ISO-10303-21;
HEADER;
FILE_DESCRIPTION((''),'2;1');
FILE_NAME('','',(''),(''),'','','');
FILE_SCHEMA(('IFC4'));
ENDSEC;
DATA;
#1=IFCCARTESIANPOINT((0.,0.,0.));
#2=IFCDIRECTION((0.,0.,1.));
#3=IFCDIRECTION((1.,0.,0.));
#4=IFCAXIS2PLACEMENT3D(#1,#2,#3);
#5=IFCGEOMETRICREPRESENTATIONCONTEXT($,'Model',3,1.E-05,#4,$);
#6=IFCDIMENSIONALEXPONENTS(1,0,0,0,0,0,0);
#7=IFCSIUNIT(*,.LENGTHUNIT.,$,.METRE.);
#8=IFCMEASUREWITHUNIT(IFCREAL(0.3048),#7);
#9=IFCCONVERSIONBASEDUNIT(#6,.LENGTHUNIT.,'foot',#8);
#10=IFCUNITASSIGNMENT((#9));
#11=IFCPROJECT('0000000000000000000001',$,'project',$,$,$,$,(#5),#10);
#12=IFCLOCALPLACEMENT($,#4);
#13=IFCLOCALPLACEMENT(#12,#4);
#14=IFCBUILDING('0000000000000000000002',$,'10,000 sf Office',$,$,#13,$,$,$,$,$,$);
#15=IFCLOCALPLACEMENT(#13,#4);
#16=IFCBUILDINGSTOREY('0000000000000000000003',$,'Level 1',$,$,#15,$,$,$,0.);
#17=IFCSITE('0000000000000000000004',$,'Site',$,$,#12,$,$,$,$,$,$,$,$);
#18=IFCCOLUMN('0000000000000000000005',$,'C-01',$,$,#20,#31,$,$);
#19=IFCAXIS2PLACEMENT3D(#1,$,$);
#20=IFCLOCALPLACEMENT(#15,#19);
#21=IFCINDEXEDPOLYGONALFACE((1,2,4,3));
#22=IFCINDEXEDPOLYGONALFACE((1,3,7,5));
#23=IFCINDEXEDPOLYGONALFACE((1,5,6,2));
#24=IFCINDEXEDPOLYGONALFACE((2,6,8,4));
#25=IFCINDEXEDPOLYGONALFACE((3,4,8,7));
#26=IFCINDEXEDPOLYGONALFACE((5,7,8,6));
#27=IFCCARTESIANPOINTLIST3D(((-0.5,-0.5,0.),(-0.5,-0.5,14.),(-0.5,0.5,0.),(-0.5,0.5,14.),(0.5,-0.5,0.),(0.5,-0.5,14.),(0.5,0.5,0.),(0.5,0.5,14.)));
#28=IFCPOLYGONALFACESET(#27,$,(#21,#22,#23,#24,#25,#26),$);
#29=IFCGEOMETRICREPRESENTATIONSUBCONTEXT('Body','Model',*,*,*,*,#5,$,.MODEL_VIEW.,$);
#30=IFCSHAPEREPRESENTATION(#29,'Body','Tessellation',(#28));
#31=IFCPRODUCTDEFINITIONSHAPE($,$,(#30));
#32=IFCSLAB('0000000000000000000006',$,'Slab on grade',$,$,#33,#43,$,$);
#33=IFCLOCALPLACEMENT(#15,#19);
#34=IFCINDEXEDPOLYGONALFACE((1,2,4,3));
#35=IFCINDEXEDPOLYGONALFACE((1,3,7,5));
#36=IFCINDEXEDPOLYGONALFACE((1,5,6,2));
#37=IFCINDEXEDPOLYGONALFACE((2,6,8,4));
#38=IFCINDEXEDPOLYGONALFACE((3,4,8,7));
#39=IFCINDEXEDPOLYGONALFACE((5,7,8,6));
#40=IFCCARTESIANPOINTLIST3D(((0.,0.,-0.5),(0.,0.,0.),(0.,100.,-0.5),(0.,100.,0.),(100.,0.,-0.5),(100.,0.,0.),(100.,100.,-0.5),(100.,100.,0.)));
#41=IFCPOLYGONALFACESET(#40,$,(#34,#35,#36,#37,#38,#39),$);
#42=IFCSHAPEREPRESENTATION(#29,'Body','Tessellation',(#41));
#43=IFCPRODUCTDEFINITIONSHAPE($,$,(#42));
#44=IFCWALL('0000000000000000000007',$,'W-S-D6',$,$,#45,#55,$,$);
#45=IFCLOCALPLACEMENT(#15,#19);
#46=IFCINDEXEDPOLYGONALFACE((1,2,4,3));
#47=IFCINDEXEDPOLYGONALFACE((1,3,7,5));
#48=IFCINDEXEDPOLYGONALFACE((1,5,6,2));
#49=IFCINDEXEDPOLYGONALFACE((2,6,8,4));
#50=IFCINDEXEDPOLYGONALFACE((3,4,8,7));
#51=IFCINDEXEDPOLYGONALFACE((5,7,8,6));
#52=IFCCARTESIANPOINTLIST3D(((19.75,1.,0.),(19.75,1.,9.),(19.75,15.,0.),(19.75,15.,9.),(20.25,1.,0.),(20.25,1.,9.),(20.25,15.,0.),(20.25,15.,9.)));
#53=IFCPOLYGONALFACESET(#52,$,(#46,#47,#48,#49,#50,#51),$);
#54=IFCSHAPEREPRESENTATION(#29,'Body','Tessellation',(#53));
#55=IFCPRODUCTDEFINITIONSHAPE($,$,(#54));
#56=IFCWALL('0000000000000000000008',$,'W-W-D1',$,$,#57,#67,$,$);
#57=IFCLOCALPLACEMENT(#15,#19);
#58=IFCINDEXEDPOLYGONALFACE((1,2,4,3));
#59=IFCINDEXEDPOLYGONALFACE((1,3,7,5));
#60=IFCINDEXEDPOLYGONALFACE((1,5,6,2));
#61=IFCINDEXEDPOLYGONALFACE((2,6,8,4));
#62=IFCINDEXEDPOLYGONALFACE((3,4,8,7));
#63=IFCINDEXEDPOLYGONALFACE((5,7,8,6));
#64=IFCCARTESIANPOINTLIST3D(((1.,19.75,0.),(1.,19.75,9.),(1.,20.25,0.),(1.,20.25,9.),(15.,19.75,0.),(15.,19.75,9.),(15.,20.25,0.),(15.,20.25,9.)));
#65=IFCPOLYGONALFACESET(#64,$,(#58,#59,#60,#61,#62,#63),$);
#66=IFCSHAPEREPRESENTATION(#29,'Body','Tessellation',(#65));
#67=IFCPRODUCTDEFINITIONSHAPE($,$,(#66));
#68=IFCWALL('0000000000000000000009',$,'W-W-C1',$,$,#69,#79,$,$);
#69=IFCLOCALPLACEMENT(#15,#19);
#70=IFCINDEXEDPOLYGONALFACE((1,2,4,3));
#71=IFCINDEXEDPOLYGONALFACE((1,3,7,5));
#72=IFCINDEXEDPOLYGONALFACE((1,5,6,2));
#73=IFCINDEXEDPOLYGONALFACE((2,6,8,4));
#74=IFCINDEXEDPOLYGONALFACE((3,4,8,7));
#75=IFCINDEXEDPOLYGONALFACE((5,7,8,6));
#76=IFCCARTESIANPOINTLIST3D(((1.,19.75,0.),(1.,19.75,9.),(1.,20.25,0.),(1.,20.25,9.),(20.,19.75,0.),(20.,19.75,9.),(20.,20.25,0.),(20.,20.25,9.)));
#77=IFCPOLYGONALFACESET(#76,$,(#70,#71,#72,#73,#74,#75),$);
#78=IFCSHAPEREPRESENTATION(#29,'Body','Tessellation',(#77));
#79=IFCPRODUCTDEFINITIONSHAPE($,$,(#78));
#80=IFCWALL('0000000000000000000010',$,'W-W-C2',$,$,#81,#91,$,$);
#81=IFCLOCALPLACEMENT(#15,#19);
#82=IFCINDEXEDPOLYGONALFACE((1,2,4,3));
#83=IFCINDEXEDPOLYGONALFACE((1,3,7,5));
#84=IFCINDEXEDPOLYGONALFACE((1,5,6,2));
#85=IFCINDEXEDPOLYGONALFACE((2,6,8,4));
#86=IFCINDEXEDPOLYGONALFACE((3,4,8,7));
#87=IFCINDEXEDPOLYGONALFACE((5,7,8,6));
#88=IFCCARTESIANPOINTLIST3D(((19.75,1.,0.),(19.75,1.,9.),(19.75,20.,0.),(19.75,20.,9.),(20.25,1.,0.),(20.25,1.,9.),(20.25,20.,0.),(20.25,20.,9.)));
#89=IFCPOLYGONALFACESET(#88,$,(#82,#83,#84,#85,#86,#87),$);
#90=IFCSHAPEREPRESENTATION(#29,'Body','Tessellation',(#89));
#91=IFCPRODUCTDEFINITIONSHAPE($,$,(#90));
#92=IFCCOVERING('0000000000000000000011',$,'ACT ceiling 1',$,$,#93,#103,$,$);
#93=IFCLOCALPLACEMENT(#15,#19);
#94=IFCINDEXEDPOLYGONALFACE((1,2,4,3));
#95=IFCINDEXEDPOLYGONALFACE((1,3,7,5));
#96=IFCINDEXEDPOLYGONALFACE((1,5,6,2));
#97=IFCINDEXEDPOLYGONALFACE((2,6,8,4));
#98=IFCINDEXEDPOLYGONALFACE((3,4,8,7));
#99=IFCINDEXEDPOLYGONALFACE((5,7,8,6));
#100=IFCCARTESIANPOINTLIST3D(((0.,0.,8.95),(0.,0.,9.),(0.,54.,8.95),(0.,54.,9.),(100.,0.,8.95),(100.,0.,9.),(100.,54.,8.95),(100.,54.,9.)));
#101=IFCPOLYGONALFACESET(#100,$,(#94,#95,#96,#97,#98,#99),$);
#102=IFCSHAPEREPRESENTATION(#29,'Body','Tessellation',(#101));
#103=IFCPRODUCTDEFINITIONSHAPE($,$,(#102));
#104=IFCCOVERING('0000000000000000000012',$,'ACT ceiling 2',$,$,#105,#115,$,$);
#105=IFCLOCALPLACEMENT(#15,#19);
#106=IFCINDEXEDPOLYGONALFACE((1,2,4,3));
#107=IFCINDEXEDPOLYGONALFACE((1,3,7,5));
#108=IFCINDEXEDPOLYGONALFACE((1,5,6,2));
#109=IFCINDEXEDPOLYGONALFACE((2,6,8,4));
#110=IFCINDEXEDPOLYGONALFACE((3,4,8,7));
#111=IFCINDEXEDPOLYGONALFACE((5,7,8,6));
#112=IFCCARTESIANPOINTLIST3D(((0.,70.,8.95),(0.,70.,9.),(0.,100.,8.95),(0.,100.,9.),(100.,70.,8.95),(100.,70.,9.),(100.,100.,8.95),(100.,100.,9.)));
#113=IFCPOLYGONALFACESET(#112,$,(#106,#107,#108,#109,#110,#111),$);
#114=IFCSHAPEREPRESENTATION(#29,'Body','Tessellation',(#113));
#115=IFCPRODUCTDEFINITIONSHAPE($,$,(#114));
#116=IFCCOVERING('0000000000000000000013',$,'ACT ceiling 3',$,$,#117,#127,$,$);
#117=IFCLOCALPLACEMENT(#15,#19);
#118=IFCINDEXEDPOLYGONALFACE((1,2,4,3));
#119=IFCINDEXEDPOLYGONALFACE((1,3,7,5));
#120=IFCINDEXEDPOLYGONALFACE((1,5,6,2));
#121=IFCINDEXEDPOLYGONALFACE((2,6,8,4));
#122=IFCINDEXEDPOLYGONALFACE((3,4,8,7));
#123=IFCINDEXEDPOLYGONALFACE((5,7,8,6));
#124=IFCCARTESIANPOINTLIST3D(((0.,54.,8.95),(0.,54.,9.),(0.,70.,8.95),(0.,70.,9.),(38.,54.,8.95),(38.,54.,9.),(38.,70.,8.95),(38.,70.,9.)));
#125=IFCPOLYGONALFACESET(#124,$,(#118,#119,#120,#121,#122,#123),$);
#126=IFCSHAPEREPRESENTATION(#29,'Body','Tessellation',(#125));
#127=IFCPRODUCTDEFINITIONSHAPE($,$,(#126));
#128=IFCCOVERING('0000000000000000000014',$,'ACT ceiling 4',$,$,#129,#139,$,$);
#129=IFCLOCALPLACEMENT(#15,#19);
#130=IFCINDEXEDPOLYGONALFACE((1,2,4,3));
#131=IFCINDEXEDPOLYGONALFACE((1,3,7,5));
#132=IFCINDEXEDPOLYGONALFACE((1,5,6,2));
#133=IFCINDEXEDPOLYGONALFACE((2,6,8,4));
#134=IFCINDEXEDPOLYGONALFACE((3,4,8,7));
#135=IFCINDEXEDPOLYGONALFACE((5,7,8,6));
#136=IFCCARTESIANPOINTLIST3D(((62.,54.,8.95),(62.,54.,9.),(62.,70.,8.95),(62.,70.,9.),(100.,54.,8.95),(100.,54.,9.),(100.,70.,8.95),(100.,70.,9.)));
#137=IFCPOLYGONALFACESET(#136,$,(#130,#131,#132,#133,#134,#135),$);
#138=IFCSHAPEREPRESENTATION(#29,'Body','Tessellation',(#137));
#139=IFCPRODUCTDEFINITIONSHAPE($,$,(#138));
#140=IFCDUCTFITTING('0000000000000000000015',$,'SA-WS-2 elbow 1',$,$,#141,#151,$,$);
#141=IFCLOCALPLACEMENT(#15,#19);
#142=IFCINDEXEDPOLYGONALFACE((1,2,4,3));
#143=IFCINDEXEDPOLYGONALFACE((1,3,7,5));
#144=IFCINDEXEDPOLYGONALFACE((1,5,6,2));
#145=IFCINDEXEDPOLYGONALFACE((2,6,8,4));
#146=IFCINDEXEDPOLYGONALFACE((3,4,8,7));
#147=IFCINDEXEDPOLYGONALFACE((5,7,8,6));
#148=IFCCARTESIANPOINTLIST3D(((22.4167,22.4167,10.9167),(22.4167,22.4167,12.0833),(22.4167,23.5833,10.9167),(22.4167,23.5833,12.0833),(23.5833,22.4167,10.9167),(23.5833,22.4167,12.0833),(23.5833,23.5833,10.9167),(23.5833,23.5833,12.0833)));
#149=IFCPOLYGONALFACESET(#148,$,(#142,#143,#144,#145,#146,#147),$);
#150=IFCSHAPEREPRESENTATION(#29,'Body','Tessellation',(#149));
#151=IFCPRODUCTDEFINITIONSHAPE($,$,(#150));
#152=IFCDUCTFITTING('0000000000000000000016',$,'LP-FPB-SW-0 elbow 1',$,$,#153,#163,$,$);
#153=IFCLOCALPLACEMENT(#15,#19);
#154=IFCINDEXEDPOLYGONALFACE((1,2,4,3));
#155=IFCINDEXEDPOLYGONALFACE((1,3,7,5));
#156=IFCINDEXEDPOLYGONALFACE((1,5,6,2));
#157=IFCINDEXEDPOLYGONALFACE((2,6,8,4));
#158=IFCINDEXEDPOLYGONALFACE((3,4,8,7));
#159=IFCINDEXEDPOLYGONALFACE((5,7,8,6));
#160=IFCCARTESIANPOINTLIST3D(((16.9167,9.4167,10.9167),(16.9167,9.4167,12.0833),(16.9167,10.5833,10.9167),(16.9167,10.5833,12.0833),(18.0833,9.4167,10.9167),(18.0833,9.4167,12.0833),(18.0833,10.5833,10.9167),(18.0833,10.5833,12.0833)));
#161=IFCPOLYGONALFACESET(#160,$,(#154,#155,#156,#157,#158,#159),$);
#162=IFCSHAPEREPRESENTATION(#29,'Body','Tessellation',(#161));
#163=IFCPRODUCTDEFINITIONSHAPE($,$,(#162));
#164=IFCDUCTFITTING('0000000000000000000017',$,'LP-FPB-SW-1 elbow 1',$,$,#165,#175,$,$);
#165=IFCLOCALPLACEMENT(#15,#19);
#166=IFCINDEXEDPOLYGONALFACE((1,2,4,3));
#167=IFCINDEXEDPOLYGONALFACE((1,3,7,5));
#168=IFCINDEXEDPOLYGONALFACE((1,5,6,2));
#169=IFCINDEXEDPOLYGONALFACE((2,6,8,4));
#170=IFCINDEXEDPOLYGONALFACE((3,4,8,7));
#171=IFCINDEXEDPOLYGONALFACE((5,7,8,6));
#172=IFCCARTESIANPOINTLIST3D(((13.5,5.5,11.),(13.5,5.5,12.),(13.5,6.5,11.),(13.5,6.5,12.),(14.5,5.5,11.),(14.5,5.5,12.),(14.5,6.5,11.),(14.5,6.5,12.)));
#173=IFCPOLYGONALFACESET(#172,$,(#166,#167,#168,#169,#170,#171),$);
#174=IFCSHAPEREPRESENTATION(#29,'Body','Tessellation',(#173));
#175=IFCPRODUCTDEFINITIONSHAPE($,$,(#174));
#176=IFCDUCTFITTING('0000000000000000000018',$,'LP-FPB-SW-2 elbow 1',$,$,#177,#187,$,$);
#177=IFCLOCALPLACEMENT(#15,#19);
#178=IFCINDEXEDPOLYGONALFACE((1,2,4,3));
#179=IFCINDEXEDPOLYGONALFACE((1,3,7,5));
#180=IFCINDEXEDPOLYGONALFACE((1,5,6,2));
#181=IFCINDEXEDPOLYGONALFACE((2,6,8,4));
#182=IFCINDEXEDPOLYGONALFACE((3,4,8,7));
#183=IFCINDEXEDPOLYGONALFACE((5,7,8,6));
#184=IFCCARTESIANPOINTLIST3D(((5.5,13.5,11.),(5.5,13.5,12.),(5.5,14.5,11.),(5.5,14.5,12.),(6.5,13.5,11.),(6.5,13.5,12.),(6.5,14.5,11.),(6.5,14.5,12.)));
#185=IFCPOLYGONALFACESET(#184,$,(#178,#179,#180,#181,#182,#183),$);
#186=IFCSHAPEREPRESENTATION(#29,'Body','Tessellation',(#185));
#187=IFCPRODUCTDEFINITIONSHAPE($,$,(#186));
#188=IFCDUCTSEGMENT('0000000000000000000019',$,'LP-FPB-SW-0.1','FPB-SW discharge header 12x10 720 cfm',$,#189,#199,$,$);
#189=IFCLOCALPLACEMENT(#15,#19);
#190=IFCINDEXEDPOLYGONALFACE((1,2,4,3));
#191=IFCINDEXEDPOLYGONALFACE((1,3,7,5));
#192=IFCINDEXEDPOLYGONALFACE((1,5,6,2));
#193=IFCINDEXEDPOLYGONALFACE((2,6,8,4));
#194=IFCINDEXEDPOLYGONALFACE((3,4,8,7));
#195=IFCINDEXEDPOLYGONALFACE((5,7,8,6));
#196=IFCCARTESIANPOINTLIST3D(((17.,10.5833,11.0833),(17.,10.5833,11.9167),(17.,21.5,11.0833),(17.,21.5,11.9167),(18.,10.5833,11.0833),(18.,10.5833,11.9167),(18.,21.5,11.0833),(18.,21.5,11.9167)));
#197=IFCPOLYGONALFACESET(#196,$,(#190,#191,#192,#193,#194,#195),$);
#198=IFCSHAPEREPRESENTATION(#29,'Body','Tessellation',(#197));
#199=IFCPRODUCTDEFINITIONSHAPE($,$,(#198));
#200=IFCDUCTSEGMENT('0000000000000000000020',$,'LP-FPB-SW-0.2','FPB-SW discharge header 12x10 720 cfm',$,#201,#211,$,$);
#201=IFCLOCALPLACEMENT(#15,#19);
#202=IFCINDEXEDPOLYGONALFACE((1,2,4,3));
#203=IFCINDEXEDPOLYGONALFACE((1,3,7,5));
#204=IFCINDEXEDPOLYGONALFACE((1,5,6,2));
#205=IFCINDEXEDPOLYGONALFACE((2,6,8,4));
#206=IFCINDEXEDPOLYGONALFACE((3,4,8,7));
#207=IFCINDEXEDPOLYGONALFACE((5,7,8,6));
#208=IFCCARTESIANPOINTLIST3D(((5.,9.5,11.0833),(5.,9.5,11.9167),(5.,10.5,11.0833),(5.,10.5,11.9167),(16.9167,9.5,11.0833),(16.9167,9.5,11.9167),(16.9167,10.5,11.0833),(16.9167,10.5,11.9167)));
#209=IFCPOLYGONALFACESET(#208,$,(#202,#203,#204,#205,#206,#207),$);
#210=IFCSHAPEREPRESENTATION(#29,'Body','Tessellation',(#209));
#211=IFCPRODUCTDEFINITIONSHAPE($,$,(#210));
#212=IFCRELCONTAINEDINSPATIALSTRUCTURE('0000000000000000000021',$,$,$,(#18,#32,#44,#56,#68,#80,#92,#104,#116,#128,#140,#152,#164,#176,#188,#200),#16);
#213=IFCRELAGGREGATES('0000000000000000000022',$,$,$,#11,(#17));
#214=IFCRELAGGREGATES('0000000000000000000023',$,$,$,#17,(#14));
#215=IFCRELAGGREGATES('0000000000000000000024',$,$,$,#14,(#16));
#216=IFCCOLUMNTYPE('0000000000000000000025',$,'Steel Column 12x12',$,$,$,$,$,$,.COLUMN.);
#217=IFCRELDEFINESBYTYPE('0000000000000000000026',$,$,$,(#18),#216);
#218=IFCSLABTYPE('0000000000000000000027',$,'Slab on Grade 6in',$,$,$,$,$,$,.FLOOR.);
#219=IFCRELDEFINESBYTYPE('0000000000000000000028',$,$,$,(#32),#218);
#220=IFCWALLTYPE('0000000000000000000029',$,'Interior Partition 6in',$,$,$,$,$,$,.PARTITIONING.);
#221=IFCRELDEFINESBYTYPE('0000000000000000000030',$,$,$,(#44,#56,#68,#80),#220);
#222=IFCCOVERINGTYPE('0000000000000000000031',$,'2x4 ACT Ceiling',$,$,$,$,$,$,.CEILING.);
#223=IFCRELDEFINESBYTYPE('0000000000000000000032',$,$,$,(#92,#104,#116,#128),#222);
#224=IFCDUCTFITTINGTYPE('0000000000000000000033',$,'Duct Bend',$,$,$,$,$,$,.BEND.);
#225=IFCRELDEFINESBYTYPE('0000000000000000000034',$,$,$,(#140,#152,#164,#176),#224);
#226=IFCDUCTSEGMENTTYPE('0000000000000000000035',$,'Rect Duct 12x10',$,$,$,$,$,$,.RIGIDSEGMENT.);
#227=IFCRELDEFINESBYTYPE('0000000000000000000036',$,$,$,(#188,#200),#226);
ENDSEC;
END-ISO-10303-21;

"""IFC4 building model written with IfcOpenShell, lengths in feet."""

from ifc_helpers import new_model, entity, si_unit, converted_unit, frame, origin_with_axes, place, context, subcontext, project, spatial, polyline, rectangle, outline, extrude, type_object, element, save


model = new_model("IFC4")

# Units and contexts
model_context = context("Model", 3, precision=1e-05, world=origin_with_axes())
body_context = subcontext(model_context, "Body", "Model", "MODEL_VIEW")
ifc_project = project(units=[converted_unit("LENGTHUNIT", "foot", entity("IfcReal", 0.3048), si_unit("LENGTHUNIT", "METRE"), dimensions=[1, 0, 0, 0, 0, 0, 0])], contexts=[model_context])

# Site, building, storey
site_placement = place(None, origin_with_axes())
site = spatial("IfcSite", under=ifc_project, at=site_placement, Name="Site")
building_placement = place(site_placement, origin_with_axes())
building = spatial("IfcBuilding", under=site, at=building_placement, Name="10,000 sf Office")
storey_placement = place(building_placement, origin_with_axes())
storey = spatial("IfcBuildingStorey", under=building, at=storey_placement, Name="Level 1", Elevation=0.0)

# Column
column_type = type_object("IfcColumnType", Name="Steel Column 12x12", PredefinedType="COLUMN")
column_placement = place(storey_placement, origin_with_axes())
element("IfcColumn", 1, at=column_placement, inside=storey, type_object=column_type, Name="C-01", context=body_context, shape_type="SweptSolid", body=[
    extrude(rectangle(XDim=1.0, YDim=1.0), None, (0.0, 0.0, 1.0), 14.0),
])

# Slab
slab_type = type_object("IfcSlabType", Name="Slab on Grade 6in", PredefinedType="FLOOR")
slab_placement = place(storey_placement, frame((0.0, 0.0, -0.5), z_axis=(0.0, 0.0, 1.0), x_axis=(1.0, 0.0, 0.0)))
element("IfcSlab", 2, at=slab_placement, inside=storey, type_object=slab_type, Name="Slab on grade", context=body_context, shape_type="SweptSolid", body=[
    extrude(outline(polyline([(0.0, 0.0), (100.0, 0.0), (100.0, 100.0), (0.0, 100.0), (0.0, 0.0)])), None, (0.0, 0.0, 1.0), 0.5),
])

# Walls
wall_type = type_object("IfcWallType", Name="Interior Partition 6in", PredefinedType="PARTITIONING")
for number, where, z_axis, x_axis, name in (
    (3, (20.0, 8.0, 0.0), (0.0, 0.0, 1.0), (0.0, 1.0, 0.0), "W-S-D6"),
    (4, (8.0, 20.0, 0.0), (0.0, 0.0, 1.0), (1.0, 0.0, 0.0), "W-W-D1"),
):
    element("IfcWall", number, at=place(storey_placement, frame(where, z_axis=z_axis, x_axis=x_axis)), inside=storey, type_object=wall_type, Name=name, context=body_context, shape_type="SweptSolid", body=[
        extrude(rectangle(XDim=14.0, YDim=0.5), None, (0.0, 0.0, 1.0), 9.0),
    ])
for number, where, z_axis, x_axis, name in (
    (5, (10.5, 20.0, 0.0), (0.0, 0.0, 1.0), (1.0, 0.0, 0.0), "W-W-C1"),
    (6, (20.0, 10.5, 0.0), (0.0, 0.0, 1.0), (0.0, -1.0, 0.0), "W-W-C2"),
):
    element("IfcWall", number, at=place(storey_placement, frame(where, z_axis=z_axis, x_axis=x_axis)), inside=storey, type_object=wall_type, Name=name, context=body_context, shape_type="SweptSolid", body=[
        extrude(rectangle(XDim=19.0, YDim=0.5), None, (0.0, 0.0, 1.0), 9.0),
    ])

# Coverings
covering_type = type_object("IfcCoveringType", Name="2x4 ACT Ceiling", PredefinedType="CEILING")
covering_1_placement = place(storey_placement, frame((0.0, 0.0, 8.95), z_axis=(0.0, 0.0, 1.0), x_axis=(1.0, 0.0, 0.0)))
element("IfcCovering", 7, at=covering_1_placement, inside=storey, type_object=covering_type, Name="ACT ceiling 1", context=body_context, shape_type="SweptSolid", body=[
    extrude(outline(polyline([(0.0, 0.0), (100.0, 0.0), (100.0, 54.0), (0.0, 54.0), (0.0, 0.0)])), None, (0.0, 0.0, 1.0), 0.05),
])
covering_2_placement = place(storey_placement, frame((0.0, 0.0, 8.95), z_axis=(0.0, 0.0, 1.0), x_axis=(1.0, 0.0, 0.0)))
element("IfcCovering", 8, at=covering_2_placement, inside=storey, type_object=covering_type, Name="ACT ceiling 2", context=body_context, shape_type="SweptSolid", body=[
    extrude(outline(polyline([(0.0, 70.0), (100.0, 70.0), (100.0, 100.0), (0.0, 100.0), (0.0, 70.0)])), None, (0.0, 0.0, 1.0), 0.05),
])
covering_3_placement = place(storey_placement, frame((0.0, 0.0, 8.95), z_axis=(0.0, 0.0, 1.0), x_axis=(1.0, 0.0, 0.0)))
element("IfcCovering", 9, at=covering_3_placement, inside=storey, type_object=covering_type, Name="ACT ceiling 3", context=body_context, shape_type="SweptSolid", body=[
    extrude(outline(polyline([(0.0, 54.0), (38.0, 54.0), (38.0, 70.0), (0.0, 70.0), (0.0, 54.0)])), None, (0.0, 0.0, 1.0), 0.05),
])
covering_4_placement = place(storey_placement, frame((0.0, 0.0, 8.95), z_axis=(0.0, 0.0, 1.0), x_axis=(1.0, 0.0, 0.0)))
element("IfcCovering", 10, at=covering_4_placement, inside=storey, type_object=covering_type, Name="ACT ceiling 4", context=body_context, shape_type="SweptSolid", body=[
    extrude(outline(polyline([(62.0, 54.0), (100.0, 54.0), (100.0, 70.0), (62.0, 70.0), (62.0, 54.0)])), None, (0.0, 0.0, 1.0), 0.05),
])

# Duct fittings
duct_fitting_type_1 = type_object("IfcDuctFittingType", Name="Duct Bend", PredefinedType="BEND")
for number, where, z_axis, x_axis, name in (
    (11, (23.0, 23.0, 10.9167), (0.0, 0.0, 1.0), (1.0, 0.0, 0.0), "SA-WS-2 elbow 1"),
    (12, (17.5, 10.0, 10.9167), (0.0, 0.0, 1.0), (1.0, 0.0, 0.0), "LP-FPB-SW-0 elbow 1"),
):
    element("IfcDuctFitting", number, at=place(storey_placement, frame(where, z_axis=z_axis, x_axis=x_axis)), inside=storey, type_object=duct_fitting_type_1, Name=name, context=body_context, shape_type="SweptSolid", body=[
        extrude(rectangle(XDim=1.1667, YDim=1.1667), None, (0.0, 0.0, 1.0), 1.1667),
    ])
for number, where, z_axis, x_axis, name in (
    (13, (14.0, 6.0, 11.0), (0.0, 0.0, 1.0), (1.0, 0.0, 0.0), "LP-FPB-SW-1 elbow 1"),
    (14, (6.0, 14.0, 11.0), (0.0, 0.0, 1.0), (1.0, 0.0, 0.0), "LP-FPB-SW-2 elbow 1"),
):
    element("IfcDuctFitting", number, at=place(storey_placement, frame(where, z_axis=z_axis, x_axis=x_axis)), inside=storey, type_object=duct_fitting_type_1, Name=name, context=body_context, shape_type="SweptSolid", body=[
        extrude(rectangle(XDim=1.0, YDim=1.0), None, (0.0, 0.0, 1.0), 1.0),
    ])

# Duct segments
duct_segment_type_1 = type_object("IfcDuctSegmentType", Name="Rect Duct 12x10", PredefinedType="RIGIDSEGMENT")
duct_segment_1_placement = place(storey_placement, frame((17.5, 21.5, 11.5), z_axis=(0.0, -1.0, 0.0), x_axis=(1.0, 0.0, 0.0)))
element("IfcDuctSegment", 15, at=duct_segment_1_placement, inside=storey, type_object=duct_segment_type_1, Name="LP-FPB-SW-0.1", Description="FPB-SW discharge header 12x10 720 cfm", context=body_context, shape_type="SweptSolid", body=[
    extrude(rectangle(XDim=1.0, YDim=0.8333), None, (0.0, 0.0, 1.0), 10.9167),
])
duct_segment_2_placement = place(storey_placement, frame((16.9167, 10.0, 11.5), z_axis=(-1.0, 0.0, 0.0), x_axis=(0.0, -1.0, 0.0)))
element("IfcDuctSegment", 16, at=duct_segment_2_placement, inside=storey, type_object=duct_segment_type_1, Name="LP-FPB-SW-0.2", Description="FPB-SW discharge header 12x10 720 cfm", context=body_context, shape_type="SweptSolid", body=[
    extrude(rectangle(XDim=1.0, YDim=0.8333), None, (0.0, 0.0, 1.0), 11.9167),
])

save(model, "model.ifc")
